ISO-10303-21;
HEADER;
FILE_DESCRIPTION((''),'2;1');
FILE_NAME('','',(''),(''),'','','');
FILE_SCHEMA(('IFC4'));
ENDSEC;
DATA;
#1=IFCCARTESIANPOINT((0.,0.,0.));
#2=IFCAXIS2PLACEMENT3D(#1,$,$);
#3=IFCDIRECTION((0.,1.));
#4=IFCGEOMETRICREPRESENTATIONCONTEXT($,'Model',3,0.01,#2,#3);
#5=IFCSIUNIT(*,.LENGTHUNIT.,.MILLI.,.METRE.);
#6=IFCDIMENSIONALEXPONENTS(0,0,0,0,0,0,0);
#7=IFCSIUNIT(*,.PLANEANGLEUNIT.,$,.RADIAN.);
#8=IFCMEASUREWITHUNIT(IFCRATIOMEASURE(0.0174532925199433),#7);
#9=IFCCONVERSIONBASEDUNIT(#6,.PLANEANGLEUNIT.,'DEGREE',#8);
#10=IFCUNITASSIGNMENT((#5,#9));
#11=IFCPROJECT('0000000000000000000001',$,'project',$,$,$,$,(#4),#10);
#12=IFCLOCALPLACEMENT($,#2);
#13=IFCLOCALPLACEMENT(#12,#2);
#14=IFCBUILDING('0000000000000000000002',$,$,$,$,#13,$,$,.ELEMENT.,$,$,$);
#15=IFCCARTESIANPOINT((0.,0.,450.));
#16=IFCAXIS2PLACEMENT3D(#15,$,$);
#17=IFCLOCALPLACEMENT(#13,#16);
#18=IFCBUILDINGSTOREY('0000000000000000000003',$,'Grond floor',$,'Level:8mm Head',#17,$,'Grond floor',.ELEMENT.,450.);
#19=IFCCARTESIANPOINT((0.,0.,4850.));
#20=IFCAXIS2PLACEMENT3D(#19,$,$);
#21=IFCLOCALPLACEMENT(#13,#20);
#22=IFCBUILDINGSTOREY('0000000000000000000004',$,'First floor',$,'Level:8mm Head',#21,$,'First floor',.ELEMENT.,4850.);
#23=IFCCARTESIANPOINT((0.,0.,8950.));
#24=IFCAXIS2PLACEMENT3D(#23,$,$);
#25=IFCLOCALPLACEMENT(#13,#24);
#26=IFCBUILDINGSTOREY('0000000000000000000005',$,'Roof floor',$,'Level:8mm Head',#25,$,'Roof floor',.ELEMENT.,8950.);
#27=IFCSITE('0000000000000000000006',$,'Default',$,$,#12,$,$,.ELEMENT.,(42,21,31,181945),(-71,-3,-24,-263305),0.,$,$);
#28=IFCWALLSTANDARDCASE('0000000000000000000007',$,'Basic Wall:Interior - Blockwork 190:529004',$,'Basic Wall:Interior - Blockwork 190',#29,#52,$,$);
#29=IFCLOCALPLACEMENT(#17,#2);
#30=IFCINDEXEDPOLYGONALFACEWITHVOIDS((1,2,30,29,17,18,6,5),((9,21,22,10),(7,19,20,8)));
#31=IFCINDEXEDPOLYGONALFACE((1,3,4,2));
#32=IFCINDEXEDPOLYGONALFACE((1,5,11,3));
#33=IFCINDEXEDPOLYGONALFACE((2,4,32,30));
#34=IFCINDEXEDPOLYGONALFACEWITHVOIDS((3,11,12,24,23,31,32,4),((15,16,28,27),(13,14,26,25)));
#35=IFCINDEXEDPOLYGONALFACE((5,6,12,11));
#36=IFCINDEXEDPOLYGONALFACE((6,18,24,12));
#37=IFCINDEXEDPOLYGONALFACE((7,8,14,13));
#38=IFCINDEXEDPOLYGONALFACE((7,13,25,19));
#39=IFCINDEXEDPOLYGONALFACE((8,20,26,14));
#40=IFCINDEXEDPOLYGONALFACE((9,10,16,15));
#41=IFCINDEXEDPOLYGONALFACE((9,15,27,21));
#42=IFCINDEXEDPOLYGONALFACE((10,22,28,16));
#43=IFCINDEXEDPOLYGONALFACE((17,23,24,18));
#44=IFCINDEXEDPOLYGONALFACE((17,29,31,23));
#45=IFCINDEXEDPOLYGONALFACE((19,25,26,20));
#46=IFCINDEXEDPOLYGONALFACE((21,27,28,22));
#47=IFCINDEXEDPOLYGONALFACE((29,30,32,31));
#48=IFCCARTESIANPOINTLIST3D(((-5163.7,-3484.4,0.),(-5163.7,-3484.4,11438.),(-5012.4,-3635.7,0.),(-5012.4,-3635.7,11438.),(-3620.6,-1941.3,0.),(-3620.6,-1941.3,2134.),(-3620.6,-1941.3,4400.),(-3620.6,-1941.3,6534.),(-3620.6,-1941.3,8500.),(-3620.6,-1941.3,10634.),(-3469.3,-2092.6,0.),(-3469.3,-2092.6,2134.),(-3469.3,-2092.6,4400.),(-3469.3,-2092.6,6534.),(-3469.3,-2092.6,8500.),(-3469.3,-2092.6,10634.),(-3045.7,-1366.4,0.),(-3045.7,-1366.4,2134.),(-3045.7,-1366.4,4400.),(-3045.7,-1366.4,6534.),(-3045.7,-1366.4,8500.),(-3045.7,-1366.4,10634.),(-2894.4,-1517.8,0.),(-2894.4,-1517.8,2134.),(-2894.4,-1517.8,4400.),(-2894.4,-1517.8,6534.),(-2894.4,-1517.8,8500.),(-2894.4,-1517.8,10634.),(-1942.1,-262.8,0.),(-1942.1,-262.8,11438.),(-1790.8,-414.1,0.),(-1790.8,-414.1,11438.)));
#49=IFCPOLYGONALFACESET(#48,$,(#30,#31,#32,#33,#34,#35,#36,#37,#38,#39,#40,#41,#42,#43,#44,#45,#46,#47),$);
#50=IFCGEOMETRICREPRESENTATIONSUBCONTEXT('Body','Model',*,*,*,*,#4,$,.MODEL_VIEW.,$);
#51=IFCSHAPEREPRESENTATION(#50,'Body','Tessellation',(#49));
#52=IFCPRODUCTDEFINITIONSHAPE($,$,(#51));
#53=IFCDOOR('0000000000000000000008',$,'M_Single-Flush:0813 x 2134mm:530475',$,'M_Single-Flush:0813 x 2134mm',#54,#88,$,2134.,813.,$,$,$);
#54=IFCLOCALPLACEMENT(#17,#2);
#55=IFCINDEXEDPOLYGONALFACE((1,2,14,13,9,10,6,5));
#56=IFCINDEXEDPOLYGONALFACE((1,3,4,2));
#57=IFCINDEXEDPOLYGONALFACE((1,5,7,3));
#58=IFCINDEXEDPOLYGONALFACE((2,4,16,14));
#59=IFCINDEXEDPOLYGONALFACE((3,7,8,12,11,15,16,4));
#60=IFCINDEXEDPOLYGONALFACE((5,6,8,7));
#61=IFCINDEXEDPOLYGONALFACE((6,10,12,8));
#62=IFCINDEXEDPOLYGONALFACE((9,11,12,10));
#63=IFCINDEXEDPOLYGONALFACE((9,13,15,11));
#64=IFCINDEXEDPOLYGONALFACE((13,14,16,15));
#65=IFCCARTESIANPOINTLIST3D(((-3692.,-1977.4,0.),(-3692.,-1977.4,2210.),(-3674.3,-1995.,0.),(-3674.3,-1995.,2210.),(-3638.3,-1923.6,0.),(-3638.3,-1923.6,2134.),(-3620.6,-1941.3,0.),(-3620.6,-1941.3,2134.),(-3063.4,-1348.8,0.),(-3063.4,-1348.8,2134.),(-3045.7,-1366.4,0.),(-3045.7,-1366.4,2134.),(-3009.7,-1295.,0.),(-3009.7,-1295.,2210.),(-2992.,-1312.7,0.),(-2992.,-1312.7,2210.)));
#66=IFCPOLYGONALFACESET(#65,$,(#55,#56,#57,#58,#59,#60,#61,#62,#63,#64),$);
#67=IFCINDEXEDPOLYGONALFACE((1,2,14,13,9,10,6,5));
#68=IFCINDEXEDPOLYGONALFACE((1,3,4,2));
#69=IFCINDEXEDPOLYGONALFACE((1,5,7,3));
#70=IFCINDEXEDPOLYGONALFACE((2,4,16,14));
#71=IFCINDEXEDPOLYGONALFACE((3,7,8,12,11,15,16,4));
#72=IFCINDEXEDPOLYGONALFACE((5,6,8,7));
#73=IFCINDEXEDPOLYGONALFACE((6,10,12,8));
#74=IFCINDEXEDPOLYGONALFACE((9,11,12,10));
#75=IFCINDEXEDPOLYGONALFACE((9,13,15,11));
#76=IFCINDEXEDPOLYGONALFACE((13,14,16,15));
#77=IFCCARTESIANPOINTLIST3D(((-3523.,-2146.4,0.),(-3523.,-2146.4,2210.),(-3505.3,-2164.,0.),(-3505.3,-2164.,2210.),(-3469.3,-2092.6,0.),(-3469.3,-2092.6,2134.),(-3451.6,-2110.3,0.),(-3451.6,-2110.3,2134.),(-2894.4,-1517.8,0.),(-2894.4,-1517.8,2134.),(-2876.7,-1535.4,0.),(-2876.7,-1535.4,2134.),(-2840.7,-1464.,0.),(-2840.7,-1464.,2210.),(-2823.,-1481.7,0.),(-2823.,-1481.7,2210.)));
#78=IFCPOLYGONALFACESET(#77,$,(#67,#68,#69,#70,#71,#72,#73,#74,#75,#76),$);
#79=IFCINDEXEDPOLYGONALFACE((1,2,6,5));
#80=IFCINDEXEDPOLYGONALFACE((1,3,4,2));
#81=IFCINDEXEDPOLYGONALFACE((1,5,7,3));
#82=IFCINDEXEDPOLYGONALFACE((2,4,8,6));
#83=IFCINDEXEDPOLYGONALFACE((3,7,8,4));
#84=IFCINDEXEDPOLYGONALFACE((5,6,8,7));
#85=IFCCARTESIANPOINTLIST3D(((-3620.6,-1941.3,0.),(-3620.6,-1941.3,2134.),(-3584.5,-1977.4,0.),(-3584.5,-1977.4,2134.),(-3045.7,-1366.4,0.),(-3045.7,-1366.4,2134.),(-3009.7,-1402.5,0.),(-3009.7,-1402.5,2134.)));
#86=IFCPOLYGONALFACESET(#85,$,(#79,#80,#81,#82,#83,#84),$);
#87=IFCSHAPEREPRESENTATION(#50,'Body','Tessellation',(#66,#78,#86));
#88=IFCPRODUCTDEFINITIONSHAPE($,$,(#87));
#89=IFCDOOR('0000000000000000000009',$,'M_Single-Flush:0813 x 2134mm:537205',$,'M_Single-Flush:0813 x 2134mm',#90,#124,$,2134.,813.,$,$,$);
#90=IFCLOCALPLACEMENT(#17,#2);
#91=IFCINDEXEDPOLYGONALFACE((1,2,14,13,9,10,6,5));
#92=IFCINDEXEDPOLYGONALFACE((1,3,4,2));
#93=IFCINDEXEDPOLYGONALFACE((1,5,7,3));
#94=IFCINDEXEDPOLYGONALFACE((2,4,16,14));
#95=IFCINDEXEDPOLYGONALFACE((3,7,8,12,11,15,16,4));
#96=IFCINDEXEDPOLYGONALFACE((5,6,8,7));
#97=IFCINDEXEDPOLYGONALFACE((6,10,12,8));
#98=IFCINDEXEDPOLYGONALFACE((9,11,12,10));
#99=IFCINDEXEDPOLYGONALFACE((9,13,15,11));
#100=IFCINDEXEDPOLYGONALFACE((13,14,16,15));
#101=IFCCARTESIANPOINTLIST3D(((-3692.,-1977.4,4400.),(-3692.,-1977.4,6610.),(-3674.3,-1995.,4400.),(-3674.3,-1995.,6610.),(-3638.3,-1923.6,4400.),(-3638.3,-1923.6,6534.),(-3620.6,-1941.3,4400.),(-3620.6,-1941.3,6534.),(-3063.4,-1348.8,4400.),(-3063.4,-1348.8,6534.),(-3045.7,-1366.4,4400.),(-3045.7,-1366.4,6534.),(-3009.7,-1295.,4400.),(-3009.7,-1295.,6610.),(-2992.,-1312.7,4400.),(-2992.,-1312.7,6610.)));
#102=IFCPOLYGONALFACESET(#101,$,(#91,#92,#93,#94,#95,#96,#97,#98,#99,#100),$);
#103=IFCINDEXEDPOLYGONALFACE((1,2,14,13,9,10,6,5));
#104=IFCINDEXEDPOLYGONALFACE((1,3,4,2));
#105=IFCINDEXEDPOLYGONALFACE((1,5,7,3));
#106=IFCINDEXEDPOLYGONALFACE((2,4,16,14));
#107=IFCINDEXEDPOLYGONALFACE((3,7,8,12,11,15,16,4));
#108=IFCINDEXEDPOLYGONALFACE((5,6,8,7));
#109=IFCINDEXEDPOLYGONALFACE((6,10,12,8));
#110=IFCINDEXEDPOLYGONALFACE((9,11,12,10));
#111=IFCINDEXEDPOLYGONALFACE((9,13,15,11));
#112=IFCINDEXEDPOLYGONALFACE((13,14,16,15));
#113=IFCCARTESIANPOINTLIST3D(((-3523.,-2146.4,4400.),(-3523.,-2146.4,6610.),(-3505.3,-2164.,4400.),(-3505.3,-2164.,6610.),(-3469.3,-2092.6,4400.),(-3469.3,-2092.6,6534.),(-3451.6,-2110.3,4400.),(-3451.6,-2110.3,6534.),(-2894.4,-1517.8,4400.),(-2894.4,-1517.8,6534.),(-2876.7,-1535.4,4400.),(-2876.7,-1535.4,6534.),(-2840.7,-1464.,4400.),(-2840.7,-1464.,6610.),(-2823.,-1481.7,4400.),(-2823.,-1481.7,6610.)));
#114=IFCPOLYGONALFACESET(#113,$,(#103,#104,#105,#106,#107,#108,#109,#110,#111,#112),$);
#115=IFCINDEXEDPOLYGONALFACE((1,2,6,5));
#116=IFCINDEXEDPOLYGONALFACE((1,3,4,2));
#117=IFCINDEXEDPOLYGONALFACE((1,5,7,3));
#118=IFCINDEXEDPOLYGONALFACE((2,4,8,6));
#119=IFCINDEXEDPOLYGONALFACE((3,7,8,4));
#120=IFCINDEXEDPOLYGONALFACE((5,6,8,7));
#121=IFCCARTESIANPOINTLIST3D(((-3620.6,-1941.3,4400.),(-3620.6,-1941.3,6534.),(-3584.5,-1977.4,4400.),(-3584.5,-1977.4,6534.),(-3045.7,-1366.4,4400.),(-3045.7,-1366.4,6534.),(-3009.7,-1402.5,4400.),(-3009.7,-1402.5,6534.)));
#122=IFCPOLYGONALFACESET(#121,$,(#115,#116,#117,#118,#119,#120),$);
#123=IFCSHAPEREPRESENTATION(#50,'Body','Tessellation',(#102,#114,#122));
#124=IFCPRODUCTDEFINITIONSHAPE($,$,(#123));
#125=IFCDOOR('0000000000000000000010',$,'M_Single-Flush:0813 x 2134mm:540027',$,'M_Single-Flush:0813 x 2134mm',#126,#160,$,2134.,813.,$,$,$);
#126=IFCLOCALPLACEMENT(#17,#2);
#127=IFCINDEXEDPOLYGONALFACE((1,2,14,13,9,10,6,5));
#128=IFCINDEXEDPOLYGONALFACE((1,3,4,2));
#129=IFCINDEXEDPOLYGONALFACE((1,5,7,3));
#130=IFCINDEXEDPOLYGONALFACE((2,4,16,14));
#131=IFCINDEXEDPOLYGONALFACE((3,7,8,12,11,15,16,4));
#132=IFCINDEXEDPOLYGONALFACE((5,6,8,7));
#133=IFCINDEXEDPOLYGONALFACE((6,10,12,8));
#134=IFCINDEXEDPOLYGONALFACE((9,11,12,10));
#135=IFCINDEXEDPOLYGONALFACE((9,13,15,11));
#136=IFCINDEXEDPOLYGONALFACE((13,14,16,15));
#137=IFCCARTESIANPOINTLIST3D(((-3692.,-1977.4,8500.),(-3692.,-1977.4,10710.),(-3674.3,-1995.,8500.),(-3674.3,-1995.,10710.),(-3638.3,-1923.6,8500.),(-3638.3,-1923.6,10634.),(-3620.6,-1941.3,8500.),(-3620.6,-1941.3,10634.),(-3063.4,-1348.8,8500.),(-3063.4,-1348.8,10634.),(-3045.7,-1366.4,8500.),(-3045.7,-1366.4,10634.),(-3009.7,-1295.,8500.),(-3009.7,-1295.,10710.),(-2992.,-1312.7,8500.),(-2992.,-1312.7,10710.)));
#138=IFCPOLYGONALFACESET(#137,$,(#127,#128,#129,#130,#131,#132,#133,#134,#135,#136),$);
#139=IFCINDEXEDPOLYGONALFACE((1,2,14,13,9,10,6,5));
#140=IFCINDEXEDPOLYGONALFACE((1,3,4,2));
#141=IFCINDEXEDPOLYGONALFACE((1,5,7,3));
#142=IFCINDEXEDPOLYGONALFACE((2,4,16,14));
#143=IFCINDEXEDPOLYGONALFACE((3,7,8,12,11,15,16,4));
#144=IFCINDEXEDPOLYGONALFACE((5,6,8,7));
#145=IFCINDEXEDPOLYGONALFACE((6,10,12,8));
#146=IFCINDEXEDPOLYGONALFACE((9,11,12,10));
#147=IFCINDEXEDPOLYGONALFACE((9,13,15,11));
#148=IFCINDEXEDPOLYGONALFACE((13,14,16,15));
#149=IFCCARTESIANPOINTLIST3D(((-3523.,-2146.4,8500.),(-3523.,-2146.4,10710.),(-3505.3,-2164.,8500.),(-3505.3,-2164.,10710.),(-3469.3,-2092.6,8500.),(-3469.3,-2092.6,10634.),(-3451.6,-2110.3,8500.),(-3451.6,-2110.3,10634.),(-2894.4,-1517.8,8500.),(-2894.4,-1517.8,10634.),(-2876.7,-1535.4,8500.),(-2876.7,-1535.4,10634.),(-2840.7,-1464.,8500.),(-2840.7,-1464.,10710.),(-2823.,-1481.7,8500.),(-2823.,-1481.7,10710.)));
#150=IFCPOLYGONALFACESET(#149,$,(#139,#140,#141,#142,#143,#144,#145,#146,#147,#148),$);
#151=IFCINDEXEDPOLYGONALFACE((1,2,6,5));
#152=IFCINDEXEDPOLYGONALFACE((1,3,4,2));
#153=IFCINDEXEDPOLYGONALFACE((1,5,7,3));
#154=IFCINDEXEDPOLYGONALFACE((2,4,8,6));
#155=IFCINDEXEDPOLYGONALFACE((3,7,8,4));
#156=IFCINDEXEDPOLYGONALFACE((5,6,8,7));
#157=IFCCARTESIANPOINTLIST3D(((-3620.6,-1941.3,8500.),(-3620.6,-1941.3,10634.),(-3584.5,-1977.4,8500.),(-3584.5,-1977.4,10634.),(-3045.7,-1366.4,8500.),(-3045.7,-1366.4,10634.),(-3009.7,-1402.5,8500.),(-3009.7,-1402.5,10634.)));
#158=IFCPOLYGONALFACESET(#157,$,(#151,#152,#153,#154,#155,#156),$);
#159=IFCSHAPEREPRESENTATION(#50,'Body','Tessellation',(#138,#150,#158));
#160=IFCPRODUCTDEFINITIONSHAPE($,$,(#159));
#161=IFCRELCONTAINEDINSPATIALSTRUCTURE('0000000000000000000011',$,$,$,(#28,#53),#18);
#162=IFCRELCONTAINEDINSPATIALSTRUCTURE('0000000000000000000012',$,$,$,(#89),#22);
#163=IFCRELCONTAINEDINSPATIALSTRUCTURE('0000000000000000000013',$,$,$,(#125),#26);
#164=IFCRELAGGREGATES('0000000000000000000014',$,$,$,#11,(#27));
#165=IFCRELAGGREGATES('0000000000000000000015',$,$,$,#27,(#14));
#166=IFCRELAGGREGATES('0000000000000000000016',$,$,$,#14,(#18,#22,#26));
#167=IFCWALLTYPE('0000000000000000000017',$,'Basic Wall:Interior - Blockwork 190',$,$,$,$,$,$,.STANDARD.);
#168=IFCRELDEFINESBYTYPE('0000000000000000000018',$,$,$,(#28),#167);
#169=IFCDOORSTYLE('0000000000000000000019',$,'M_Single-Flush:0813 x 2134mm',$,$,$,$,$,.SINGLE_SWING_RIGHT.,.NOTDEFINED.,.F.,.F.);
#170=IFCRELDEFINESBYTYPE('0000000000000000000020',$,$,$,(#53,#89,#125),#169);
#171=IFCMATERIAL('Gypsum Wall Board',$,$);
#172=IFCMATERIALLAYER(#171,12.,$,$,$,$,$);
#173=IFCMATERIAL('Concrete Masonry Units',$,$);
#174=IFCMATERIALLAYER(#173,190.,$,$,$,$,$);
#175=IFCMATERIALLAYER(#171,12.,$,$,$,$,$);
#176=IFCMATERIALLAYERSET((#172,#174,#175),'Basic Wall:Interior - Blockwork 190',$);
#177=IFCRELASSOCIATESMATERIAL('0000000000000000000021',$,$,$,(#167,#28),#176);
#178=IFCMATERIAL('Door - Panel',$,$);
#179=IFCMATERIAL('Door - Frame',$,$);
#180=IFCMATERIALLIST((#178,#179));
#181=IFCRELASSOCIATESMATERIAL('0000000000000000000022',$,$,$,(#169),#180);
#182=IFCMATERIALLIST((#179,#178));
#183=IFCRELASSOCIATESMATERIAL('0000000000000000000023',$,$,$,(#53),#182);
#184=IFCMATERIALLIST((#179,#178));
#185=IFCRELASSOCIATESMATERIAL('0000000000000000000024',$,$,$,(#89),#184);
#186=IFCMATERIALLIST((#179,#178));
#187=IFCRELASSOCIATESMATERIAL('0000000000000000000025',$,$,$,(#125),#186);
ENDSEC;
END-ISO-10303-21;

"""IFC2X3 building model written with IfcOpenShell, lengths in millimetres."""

from ifc_helpers import new_model, entity, si_unit, converted_unit, direction, frame, frame_2d, origin, place, context, subcontext, project, spatial, polyline, rectangle, outline, extrude, source, transform, mapped, material, material_list, layer, layer_set, layer_usage, type_object, type_shapes, element, fill, save


model = new_model("IFC2X3")

# Units and contexts
model_context = context("Model", 3, precision=0.01, world=origin(), true_north=direction((0.0, 1.0)))
body_context = subcontext(model_context, "Body", "Model", "MODEL_VIEW")
ifc_project = project(units=[si_unit("LENGTHUNIT", "METRE", prefix="MILLI"), converted_unit("PLANEANGLEUNIT", "DEGREE", entity("IfcRatioMeasure", 0.0174532925199433), si_unit("PLANEANGLEUNIT", "RADIAN"), dimensions=[0, 0, 0, 0, 0, 0, 0])], contexts=[model_context])

# Site, building, storey
site_placement = place(None, origin())
site = spatial("IfcSite", under=ifc_project, at=site_placement, Name="Default", CompositionType="ELEMENT", RefLatitude=(42, 21, 31, 181945), RefLongitude=(-71, -3, -24, -263305), RefElevation=0.0)
building_placement = place(site_placement, origin())
building = spatial("IfcBuilding", under=site, at=building_placement, CompositionType="ELEMENT")
storey_1_placement = place(building_placement, frame((0.0, 0.0, 450.0)))
storey_1 = spatial("IfcBuildingStorey", under=building, at=storey_1_placement, Name="Grond floor", ObjectType="Level:8mm Head", LongName="Grond floor", CompositionType="ELEMENT", Elevation=450.0)

# Wall, openings, door
ifc_material_1 = material(Name="Gypsum Wall Board")
ifc_layer_1 = layer(ifc_material_1, 12.0)
ifc_material_2 = material(Name="Concrete Masonry Units")
ifc_layer_2 = layer(ifc_material_2, 190.0)
ifc_layer_3 = layer(ifc_material_1, 12.0)
ifc_layer_set_1 = layer_set([ifc_layer_1, ifc_layer_2, ifc_layer_3], Name="Basic Wall:Interior - Blockwork 190")
ifc_layer_usage_1 = layer_usage(ifc_layer_set_1, "AXIS2", "NEGATIVE", 107.0)
wall_type_1 = type_object("IfcWallType", Name="Basic Wall:Interior - Blockwork 190", PredefinedType="STANDARD", material=ifc_layer_set_1)
wall_1_placement = place(storey_1_placement, frame((-1866.4, -338.5, 0.0), z_axis=(0.0, 0.0, 1.0), x_axis=(-0.707107, -0.707107, 0.0)))
wall_1 = element("IfcWallStandardCase", 1, at=wall_1_placement, inside=storey_1, type_object=wall_type_1, material=ifc_layer_usage_1, Name="Basic Wall:Interior - Blockwork 190:529004", ObjectType="Basic Wall:Interior - Blockwork 190", context=body_context, shape_type="SweptSolid", body=[
    extrude(rectangle(XDim=4556.0, YDim=214.0, at=frame_2d((2278.0, 0.0), x_axis=(-1.0, 0.0))), origin(), (0.0, 0.0, 1.0), 11438.0),
])
opening_1_placement = place(wall_1_placement, frame((2373.8, 107.0, 0.0)))
opening_1 = element("IfcOpeningElement", 2, at=opening_1_placement, cuts=wall_1, ObjectType="Opening", context=body_context, shape_type="SweptSolid", body=[
    extrude(rectangle(XDim=813.0, YDim=2134.0, at=frame_2d((1067.0, 406.5), x_axis=(0.0, 1.0))), frame((0.0, 0.0, 0.0), z_axis=(0.0, -1.0, 0.0), x_axis=(0.0, 0.0, 1.0)), (0.0, 0.0, 1.0), 214.0),
])
opening_2_placement = place(wall_1_placement, frame((2373.8, 107.0, 4400.0)))
opening_2 = element("IfcOpeningElement", 3, at=opening_2_placement, cuts=wall_1, ObjectType="Opening", context=body_context, shape_type="SweptSolid", body=[
    extrude(rectangle(XDim=813.0, YDim=2134.0, at=frame_2d((1067.0, 406.5), x_axis=(0.0, 1.0))), frame((0.0, 0.0, 0.0), z_axis=(0.0, -1.0, 0.0), x_axis=(0.0, 0.0, 1.0)), (0.0, 0.0, 1.0), 214.0),
])
opening_3_placement = place(wall_1_placement, frame((2373.8, 107.0, 8500.0)))
opening_3 = element("IfcOpeningElement", 4, at=opening_3_placement, cuts=wall_1, ObjectType="Opening", context=body_context, shape_type="SweptSolid", body=[
    extrude(rectangle(XDim=813.0, YDim=2134.0, at=frame_2d((1067.0, 406.5), x_axis=(0.0, 1.0))), frame((0.0, 0.0, 0.0), z_axis=(0.0, -1.0, 0.0), x_axis=(0.0, 0.0, 1.0)), (0.0, 0.0, 1.0), 214.0),
])
ifc_material_3 = material(Name="Door - Frame")
ifc_material_4 = material(Name="Door - Panel")
ifc_material_list_1 = material_list([ifc_material_3, ifc_material_4])
ifc_material_list_2 = material_list([ifc_material_4, ifc_material_3])
door_style_1 = type_object("IfcDoorStyle", Name="M_Single-Flush:0813 x 2134mm", ConstructionType="NOTDEFINED", OperationType="SINGLE_SWING_RIGHT", ParameterTakesPrecedence=False, Sizeable=False, material=ifc_material_list_2)
shared_shape_1 = source(origin(), body_context, "Body", "SweptSolid", [
    extrude(outline(polyline([(-482.5, -1124.0), (482.5, -1124.0), (482.5, 1086.0), (406.5, 1086.0), (406.5, -1048.0), (-406.5, -1048.0), (-406.5, 1086.0), (-482.5, 1086.0), (-482.5, -1124.0)])), frame((406.5, 214.0, 1086.0), z_axis=(0.0, 1.0, 0.0), x_axis=(1.0, 0.0, 0.0)), (0.0, 0.0, 1.0), 25.0),
    extrude(outline(polyline([(-1124.0, -482.5), (1086.0, -482.5), (1086.0, -406.5), (-1048.0, -406.5), (-1048.0, 406.5), (1086.0, 406.5), (1086.0, 482.5), (-1124.0, 482.5), (-1124.0, -482.5)])), frame((406.5, -25.0, 1086.0), z_axis=(0.0, 1.0, 0.0), x_axis=(0.0, 0.0, -1.0)), (0.0, 0.0, 1.0), 25.0),
    extrude(rectangle(XDim=51.0, YDim=813.0, at=frame_2d((0.0, 0.0), x_axis=(1.0, 0.0))), frame((406.5, 188.5, 0.0), z_axis=(0.0, 0.0, 1.0), x_axis=(0.0, 1.0, 0.0)), (0.0, 0.0, 1.0), 2134.0),
])
type_shapes(door_style_1, [shared_shape_1])
door_1_placement = place(opening_1_placement, frame((0.0, 0.0, 0.0), z_axis=(0.0, 0.0, 1.0), x_axis=(-1.0, 0.0, 0.0)))
door_1 = element("IfcDoor", 5, at=door_1_placement, inside=storey_1, type_object=door_style_1, material=ifc_material_list_1, Name="M_Single-Flush:0813 x 2134mm:530475", ObjectType="M_Single-Flush:0813 x 2134mm", OverallHeight=2134.0, OverallWidth=813.0, context=body_context, shape_type="MappedRepresentation", body=[
    mapped(shared_shape_1, transform((0.0, 0.0, 0.0), scale=1.0)),
])
fill(opening_1, door_1)

# Shared definitions
storey_2_placement = place(building_placement, frame((0.0, 0.0, 4850.0)))
storey_2 = spatial("IfcBuildingStorey", under=building, at=storey_2_placement, Name="First floor", ObjectType="Level:8mm Head", LongName="First floor", CompositionType="ELEMENT", Elevation=4850.0)

# Door
ifc_material_list_3 = material_list([ifc_material_3, ifc_material_4])
door_2_placement = place(opening_2_placement, frame((0.0, 0.0, 0.0), z_axis=(0.0, 0.0, 1.0), x_axis=(-1.0, 0.0, 0.0)))
door_2 = element("IfcDoor", 6, at=door_2_placement, inside=storey_2, type_object=door_style_1, material=ifc_material_list_3, Name="M_Single-Flush:0813 x 2134mm:537205", ObjectType="M_Single-Flush:0813 x 2134mm", OverallHeight=2134.0, OverallWidth=813.0, context=body_context, shape_type="MappedRepresentation", body=[
    mapped(shared_shape_1, transform((0.0, 0.0, 0.0), scale=1.0)),
])
fill(opening_2, door_2)

# Shared definitions
storey_3_placement = place(building_placement, frame((0.0, 0.0, 8950.0)))
storey_3 = spatial("IfcBuildingStorey", under=building, at=storey_3_placement, Name="Roof floor", ObjectType="Level:8mm Head", LongName="Roof floor", CompositionType="ELEMENT", Elevation=8950.0)

# Door
ifc_material_list_4 = material_list([ifc_material_3, ifc_material_4])
door_3_placement = place(opening_3_placement, frame((0.0, 0.0, 0.0), z_axis=(0.0, 0.0, 1.0), x_axis=(-1.0, 0.0, 0.0)))
door_3 = element("IfcDoor", 7, at=door_3_placement, inside=storey_3, type_object=door_style_1, material=ifc_material_list_4, Name="M_Single-Flush:0813 x 2134mm:540027", ObjectType="M_Single-Flush:0813 x 2134mm", OverallHeight=2134.0, OverallWidth=813.0, context=body_context, shape_type="MappedRepresentation", body=[
    mapped(shared_shape_1, transform((0.0, 0.0, 0.0), scale=1.0)),
])
fill(opening_3, door_3)

save(model, "model.ifc")
